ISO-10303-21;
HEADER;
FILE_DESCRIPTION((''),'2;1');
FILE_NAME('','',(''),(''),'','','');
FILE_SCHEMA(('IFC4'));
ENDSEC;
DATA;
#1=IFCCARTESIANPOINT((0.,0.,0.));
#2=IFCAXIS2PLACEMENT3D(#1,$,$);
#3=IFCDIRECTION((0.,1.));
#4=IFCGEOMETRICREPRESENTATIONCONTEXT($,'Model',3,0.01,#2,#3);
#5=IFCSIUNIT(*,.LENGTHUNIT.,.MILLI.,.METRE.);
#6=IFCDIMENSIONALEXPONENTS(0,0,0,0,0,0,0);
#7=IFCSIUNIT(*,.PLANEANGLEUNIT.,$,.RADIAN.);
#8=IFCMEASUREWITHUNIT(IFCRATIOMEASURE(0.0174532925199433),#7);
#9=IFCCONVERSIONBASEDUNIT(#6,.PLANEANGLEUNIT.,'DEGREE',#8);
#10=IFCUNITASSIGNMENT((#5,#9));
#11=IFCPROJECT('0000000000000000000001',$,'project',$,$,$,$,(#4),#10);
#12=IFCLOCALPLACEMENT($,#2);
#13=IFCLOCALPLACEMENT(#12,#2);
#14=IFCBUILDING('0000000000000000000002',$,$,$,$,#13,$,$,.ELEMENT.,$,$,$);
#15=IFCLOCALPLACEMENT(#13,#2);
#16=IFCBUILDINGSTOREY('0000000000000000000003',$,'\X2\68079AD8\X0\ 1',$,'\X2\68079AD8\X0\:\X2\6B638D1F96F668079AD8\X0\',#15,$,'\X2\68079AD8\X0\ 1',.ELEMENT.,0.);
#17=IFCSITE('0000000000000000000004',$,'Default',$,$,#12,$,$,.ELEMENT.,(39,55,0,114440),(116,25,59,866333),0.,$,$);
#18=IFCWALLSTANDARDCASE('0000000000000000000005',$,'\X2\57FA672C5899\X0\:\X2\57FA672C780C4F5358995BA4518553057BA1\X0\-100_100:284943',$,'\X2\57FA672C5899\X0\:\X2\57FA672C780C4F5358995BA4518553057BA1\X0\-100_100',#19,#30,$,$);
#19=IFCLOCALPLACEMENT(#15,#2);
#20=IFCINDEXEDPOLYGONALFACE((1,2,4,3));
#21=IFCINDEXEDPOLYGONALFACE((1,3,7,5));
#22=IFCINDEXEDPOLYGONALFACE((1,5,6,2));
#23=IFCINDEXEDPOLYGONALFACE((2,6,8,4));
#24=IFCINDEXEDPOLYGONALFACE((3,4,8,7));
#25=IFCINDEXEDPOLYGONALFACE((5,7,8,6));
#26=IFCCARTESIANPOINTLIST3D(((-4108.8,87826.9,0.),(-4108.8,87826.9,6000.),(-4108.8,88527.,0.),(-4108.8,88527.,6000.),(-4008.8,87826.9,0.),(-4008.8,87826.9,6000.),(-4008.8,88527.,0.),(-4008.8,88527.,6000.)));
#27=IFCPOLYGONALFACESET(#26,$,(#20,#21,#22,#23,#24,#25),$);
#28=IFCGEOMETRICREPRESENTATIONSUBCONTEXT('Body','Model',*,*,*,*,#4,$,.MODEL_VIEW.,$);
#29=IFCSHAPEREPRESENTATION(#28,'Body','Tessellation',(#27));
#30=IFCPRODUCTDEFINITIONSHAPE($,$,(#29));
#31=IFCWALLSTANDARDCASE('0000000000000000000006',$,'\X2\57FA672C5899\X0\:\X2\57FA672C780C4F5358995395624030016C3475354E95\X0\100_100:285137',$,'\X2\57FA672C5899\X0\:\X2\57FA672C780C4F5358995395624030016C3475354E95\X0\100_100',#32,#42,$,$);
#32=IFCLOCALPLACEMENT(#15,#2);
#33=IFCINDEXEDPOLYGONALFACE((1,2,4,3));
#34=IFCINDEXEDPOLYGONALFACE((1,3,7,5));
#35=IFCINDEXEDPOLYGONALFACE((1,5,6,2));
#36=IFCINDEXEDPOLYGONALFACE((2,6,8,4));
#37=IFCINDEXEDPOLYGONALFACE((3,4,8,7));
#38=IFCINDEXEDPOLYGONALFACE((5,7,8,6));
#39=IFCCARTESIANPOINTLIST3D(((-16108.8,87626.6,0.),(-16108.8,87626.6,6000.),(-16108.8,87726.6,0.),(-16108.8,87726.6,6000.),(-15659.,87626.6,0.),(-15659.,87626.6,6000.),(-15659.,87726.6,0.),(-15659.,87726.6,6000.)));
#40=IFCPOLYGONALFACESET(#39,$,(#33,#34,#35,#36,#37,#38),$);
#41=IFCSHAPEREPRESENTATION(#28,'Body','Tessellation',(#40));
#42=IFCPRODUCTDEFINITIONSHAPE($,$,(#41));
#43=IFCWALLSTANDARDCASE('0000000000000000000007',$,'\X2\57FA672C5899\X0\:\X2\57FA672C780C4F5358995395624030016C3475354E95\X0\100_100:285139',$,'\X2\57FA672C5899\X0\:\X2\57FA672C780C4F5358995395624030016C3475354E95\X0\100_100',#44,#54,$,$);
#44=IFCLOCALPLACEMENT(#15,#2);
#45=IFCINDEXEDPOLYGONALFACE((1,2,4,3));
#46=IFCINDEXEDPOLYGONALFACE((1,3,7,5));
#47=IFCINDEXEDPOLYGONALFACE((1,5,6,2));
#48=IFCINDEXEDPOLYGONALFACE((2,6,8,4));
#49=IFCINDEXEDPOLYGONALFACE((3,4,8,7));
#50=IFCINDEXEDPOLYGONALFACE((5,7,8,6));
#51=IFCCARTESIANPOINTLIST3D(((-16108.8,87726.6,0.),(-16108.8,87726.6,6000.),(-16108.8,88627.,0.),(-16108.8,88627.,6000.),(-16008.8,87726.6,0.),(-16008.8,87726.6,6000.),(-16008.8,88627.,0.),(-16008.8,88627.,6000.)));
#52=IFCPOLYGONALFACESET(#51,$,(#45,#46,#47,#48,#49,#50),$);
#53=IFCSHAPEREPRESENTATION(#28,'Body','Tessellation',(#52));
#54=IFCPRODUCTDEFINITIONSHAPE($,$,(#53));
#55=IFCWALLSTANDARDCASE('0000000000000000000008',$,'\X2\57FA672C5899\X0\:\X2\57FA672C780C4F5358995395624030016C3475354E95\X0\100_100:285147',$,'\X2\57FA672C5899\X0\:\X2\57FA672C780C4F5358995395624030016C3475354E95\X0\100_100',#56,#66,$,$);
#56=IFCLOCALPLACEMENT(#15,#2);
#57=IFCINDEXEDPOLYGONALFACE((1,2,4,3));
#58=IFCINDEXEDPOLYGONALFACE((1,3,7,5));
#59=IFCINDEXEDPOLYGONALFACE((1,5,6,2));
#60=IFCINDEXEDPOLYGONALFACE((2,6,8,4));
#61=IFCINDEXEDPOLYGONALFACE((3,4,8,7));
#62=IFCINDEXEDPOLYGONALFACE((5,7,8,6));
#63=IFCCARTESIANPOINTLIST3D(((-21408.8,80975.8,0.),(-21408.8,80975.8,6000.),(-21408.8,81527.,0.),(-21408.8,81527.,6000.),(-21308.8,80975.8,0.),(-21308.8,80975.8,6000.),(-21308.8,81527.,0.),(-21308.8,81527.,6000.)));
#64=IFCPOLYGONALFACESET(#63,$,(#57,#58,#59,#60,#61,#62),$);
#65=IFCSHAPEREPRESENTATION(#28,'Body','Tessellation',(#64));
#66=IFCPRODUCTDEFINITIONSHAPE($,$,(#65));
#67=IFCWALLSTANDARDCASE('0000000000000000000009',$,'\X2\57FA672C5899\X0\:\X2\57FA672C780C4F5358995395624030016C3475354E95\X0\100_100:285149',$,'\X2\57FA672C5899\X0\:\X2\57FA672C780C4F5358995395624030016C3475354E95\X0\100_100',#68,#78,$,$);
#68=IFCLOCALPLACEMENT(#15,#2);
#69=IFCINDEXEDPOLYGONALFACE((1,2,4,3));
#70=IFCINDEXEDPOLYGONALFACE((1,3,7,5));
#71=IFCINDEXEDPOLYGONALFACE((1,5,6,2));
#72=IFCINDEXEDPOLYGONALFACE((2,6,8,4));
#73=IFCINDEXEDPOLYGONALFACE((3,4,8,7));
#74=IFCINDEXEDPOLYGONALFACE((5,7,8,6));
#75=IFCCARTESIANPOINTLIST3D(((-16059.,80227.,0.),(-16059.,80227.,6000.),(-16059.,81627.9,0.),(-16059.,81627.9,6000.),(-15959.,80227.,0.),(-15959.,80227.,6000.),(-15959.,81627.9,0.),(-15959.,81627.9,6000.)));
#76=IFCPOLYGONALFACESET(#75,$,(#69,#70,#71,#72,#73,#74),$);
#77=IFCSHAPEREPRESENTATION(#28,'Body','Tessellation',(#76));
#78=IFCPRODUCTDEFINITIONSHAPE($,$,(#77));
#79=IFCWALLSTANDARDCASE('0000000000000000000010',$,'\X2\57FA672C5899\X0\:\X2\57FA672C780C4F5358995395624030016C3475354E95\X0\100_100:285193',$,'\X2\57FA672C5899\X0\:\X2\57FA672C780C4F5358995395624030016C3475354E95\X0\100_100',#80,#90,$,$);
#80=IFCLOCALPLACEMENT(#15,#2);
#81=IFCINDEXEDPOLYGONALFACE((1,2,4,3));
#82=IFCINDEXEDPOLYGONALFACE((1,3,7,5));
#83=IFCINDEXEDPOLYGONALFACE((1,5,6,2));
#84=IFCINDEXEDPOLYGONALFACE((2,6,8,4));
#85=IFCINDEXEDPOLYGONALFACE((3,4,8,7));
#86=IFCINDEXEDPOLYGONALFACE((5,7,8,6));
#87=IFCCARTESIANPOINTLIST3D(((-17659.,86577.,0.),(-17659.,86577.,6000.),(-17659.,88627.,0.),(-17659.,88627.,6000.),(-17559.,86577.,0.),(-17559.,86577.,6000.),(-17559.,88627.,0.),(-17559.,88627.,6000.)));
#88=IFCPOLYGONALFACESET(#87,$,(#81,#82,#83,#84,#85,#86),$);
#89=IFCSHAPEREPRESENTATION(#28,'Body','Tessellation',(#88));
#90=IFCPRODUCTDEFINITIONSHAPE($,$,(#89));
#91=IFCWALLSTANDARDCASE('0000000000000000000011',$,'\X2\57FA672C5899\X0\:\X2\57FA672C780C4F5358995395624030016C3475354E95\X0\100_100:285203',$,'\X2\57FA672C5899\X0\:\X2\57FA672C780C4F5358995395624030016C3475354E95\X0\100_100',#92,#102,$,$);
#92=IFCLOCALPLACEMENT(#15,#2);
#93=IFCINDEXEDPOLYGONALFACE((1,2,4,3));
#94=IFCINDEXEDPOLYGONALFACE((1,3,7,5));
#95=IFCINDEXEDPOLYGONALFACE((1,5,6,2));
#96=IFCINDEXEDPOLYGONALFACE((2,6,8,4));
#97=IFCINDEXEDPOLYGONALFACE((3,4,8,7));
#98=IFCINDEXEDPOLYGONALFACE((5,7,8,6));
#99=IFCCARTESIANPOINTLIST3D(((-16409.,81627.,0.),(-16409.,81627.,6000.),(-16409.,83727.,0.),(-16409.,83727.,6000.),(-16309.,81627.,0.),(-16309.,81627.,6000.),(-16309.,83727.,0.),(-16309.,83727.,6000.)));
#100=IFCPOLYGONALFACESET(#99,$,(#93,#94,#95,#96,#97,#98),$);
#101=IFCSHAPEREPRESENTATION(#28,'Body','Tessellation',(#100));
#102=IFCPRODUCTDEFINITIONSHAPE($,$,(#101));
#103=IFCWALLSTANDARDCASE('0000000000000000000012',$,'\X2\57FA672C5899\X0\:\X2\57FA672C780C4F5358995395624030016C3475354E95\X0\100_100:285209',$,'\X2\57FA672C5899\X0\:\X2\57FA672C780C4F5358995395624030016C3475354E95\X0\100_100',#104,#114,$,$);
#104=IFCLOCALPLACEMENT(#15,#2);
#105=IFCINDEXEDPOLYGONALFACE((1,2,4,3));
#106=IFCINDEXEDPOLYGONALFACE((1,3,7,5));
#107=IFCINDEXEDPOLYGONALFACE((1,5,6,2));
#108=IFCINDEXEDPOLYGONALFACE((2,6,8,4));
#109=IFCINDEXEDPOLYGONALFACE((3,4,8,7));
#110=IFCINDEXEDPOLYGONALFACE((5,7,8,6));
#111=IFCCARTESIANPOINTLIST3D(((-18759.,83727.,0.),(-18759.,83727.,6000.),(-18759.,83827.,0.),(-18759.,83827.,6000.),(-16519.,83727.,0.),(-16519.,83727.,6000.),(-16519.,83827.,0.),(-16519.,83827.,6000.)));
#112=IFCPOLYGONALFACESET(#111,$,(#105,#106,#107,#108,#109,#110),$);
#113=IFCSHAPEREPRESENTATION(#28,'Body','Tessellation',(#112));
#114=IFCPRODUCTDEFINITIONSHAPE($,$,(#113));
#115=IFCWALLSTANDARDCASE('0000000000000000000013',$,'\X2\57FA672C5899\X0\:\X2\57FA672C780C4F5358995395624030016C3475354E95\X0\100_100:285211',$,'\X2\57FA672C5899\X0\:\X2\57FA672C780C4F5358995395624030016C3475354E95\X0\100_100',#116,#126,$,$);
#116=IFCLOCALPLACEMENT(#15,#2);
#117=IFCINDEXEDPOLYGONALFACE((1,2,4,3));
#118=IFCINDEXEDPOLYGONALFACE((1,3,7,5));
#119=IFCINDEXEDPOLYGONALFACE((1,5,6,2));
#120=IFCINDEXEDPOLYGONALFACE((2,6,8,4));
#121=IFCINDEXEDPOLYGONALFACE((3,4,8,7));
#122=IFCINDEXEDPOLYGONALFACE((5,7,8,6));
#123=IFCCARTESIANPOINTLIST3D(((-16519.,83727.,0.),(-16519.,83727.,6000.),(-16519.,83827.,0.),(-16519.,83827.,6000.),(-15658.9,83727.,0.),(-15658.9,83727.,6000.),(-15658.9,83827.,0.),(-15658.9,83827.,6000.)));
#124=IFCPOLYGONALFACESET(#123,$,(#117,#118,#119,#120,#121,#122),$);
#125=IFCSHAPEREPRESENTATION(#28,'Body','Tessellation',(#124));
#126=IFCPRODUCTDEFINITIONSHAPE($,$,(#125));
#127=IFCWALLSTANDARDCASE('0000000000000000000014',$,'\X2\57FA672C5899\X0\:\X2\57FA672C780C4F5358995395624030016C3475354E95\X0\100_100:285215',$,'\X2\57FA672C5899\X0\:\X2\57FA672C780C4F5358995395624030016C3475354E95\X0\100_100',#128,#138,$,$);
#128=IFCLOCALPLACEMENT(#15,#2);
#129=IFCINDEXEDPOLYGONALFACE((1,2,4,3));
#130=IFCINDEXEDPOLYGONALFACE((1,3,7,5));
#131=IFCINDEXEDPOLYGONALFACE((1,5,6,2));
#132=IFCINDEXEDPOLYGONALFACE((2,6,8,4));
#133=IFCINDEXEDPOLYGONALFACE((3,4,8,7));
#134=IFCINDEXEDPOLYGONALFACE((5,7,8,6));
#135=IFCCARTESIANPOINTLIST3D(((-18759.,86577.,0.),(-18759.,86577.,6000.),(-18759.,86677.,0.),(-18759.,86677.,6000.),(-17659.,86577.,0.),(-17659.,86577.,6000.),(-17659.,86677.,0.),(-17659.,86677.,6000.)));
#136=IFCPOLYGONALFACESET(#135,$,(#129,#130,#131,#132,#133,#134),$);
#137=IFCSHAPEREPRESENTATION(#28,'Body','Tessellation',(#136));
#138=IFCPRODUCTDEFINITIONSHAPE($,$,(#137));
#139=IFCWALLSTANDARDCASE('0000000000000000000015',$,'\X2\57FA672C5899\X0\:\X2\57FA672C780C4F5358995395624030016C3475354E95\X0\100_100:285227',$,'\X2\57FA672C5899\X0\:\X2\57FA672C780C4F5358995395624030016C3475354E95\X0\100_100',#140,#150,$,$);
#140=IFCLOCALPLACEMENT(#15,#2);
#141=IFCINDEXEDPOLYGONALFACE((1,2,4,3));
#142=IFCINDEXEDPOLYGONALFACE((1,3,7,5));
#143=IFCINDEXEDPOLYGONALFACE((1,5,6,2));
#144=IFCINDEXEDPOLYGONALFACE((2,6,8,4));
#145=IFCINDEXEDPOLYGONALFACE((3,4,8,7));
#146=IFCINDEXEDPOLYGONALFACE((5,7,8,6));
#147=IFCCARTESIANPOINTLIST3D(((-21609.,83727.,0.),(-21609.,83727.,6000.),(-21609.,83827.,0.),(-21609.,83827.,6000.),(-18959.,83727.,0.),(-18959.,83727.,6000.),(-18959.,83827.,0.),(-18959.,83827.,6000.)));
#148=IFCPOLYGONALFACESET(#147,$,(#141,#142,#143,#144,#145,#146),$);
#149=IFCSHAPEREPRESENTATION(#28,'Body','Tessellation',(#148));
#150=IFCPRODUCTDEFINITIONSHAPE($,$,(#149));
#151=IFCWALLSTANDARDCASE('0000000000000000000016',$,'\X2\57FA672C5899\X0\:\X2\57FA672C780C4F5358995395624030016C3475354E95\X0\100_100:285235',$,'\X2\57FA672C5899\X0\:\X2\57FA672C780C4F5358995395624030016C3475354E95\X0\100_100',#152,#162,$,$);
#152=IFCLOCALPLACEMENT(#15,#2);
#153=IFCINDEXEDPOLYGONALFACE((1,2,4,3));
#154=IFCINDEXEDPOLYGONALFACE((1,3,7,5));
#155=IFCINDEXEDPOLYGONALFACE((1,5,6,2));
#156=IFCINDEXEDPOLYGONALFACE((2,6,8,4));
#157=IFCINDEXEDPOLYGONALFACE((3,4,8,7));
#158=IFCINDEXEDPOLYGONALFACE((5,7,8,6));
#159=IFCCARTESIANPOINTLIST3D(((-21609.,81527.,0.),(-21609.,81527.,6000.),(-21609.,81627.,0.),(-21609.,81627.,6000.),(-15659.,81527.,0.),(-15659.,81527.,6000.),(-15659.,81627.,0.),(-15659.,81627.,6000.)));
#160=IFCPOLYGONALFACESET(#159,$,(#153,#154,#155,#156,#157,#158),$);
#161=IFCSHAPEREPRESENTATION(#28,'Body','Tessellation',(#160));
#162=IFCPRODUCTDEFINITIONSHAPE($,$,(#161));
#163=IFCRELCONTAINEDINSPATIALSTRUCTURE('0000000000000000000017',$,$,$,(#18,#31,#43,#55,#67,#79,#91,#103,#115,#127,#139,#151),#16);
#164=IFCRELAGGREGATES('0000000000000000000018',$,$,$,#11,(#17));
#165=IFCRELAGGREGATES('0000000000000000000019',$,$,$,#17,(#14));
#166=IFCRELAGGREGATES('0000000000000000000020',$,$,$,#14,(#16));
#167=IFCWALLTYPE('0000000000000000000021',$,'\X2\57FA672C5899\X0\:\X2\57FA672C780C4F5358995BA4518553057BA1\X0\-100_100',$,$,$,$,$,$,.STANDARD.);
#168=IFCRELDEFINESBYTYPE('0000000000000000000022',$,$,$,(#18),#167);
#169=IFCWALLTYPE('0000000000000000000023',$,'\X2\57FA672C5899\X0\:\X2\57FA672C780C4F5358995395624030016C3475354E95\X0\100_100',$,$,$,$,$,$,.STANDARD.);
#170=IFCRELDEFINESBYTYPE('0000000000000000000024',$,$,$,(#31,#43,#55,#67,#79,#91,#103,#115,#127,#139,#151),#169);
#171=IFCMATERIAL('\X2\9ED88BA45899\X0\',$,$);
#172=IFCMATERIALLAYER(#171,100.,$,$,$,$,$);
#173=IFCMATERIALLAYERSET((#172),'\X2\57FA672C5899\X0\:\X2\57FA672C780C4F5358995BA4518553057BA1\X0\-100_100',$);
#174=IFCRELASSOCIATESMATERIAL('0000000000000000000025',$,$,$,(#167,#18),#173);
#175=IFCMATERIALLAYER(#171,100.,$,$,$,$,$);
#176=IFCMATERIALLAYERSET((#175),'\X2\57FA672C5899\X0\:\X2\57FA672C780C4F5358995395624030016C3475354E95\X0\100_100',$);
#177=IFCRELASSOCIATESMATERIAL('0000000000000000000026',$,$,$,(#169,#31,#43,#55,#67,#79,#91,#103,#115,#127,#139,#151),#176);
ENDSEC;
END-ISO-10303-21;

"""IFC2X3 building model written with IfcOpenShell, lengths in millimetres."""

from ifc_helpers import new_model, entity, si_unit, converted_unit, direction, frame, frame_2d, origin, place, context, subcontext, project, spatial, rectangle, extrude, material, layer, layer_set, layer_usage, type_object, element, save


model = new_model("IFC2X3")

# Units and contexts
model_context = context("Model", 3, precision=0.01, world=origin(), true_north=direction((0.0, 1.0)))
body_context = subcontext(model_context, "Body", "Model", "MODEL_VIEW")
ifc_project = project(units=[si_unit("LENGTHUNIT", "METRE", prefix="MILLI"), converted_unit("PLANEANGLEUNIT", "DEGREE", entity("IfcRatioMeasure", 0.0174532925199433), si_unit("PLANEANGLEUNIT", "RADIAN"), dimensions=[0, 0, 0, 0, 0, 0, 0])], contexts=[model_context])

# Site, building, storey
site_placement = place(None, origin())
site = spatial("IfcSite", under=ifc_project, at=site_placement, Name="Default", CompositionType="ELEMENT", RefLatitude=(39, 55, 0, 114440), RefLongitude=(116, 25, 59, 866333), RefElevation=0.0)
building_placement = place(site_placement, origin())
building = spatial("IfcBuilding", under=site, at=building_placement, CompositionType="ELEMENT")
storey_placement = place(building_placement, origin())
storey = spatial("IfcBuildingStorey", under=building, at=storey_placement, Name="标高 1", ObjectType="标高:正负零标高", LongName="标高 1", CompositionType="ELEMENT", Elevation=0.0)

# Walls
ifc_material = material(Name="默认墙")
ifc_layer_1 = layer(ifc_material, 100.0)
ifc_layer_set_1 = layer_set([ifc_layer_1], Name="基本墙:基本砌体墙室内包管-100_100")
wall_type_1 = type_object("IfcWallType", Name="基本墙:基本砌体墙室内包管-100_100", PredefinedType="STANDARD", material=ifc_layer_set_1)
ifc_layer_usage_1 = layer_usage(ifc_layer_set_1, "AXIS2", "NEGATIVE", 50.0)
wall_1_placement = place(building_placement, frame((-4058.8, 87826.9, 0.0), z_axis=(0.0, 0.0, 1.0), x_axis=(0.0, 1.0, 0.0)))
element("IfcWallStandardCase", 1, at=wall_1_placement, inside=storey, type_object=wall_type_1, material=ifc_layer_usage_1, Name="基本墙:基本砌体墙室内包管-100_100:284943", ObjectType="基本墙:基本砌体墙室内包管-100_100", context=body_context, shape_type="SweptSolid", body=[
    extrude(rectangle(XDim=700.1, YDim=100.0, at=frame_2d((350.0, 0.0), x_axis=(-1.0, 0.0))), origin(), (0.0, 0.0, 1.0), 6000.0),
])
ifc_layer_2 = layer(ifc_material, 100.0)
ifc_layer_set_2 = layer_set([ifc_layer_2], Name="基本墙:基本砌体墙厕所、水电井100_100")
ifc_layer_usage_2 = layer_usage(ifc_layer_set_2, "AXIS2", "NEGATIVE", 50.0)
wall_type_2 = type_object("IfcWallType", Name="基本墙:基本砌体墙厕所、水电井100_100", PredefinedType="STANDARD", material=ifc_layer_set_2)
wall_2_placement = place(building_placement, frame((-16108.8, 87676.6, 0.0)))
element("IfcWallStandardCase", 2, at=wall_2_placement, inside=storey, type_object=wall_type_2, material=ifc_layer_usage_2, Name="基本墙:基本砌体墙厕所、水电井100_100:285137", ObjectType="基本墙:基本砌体墙厕所、水电井100_100", context=body_context, shape_type="SweptSolid", body=[
    extrude(rectangle(XDim=449.8, YDim=100.0, at=frame_2d((224.9, 0.0), x_axis=(-1.0, 0.0))), origin(), (0.0, 0.0, 1.0), 6000.0),
])
ifc_layer_usage_3 = layer_usage(ifc_layer_set_2, "AXIS2", "NEGATIVE", 50.0)
wall_3_placement = place(building_placement, frame((-16058.8, 87726.6, 0.0), z_axis=(0.0, 0.0, 1.0), x_axis=(0.0, 1.0, 0.0)))
element("IfcWallStandardCase", 3, at=wall_3_placement, inside=storey, type_object=wall_type_2, material=ifc_layer_usage_3, Name="基本墙:基本砌体墙厕所、水电井100_100:285139", ObjectType="基本墙:基本砌体墙厕所、水电井100_100", context=body_context, shape_type="SweptSolid", body=[
    extrude(rectangle(XDim=900.5, YDim=100.0, at=frame_2d((450.2, 0.0), x_axis=(-1.0, 0.0))), origin(), (0.0, 0.0, 1.0), 6000.0),
])
ifc_layer_usage_4 = layer_usage(ifc_layer_set_2, "AXIS2", "NEGATIVE", 50.0)
wall_4_placement = place(building_placement, frame((-21358.8, 80975.8, 0.0), z_axis=(0.0, 0.0, 1.0), x_axis=(0.0, 1.0, 0.0)))
element("IfcWallStandardCase", 4, at=wall_4_placement, inside=storey, type_object=wall_type_2, material=ifc_layer_usage_4, Name="基本墙:基本砌体墙厕所、水电井100_100:285147", ObjectType="基本墙:基本砌体墙厕所、水电井100_100", context=body_context, shape_type="SweptSolid", body=[
    extrude(rectangle(XDim=551.2, YDim=100.0, at=frame_2d((275.6, 0.0), x_axis=(-1.0, 0.0))), origin(), (0.0, 0.0, 1.0), 6000.0),
])
ifc_layer_usage_5 = layer_usage(ifc_layer_set_2, "AXIS2", "NEGATIVE", 50.0)
wall_5_placement = place(building_placement, frame((-16009.0, 81627.9, 0.0), z_axis=(0.0, 0.0, 1.0), x_axis=(0.0, -1.0, 0.0)))
element("IfcWallStandardCase", 5, at=wall_5_placement, inside=storey, type_object=wall_type_2, material=ifc_layer_usage_5, Name="基本墙:基本砌体墙厕所、水电井100_100:285149", ObjectType="基本墙:基本砌体墙厕所、水电井100_100", context=body_context, shape_type="SweptSolid", body=[
    extrude(rectangle(XDim=1400.9, YDim=100.0, at=frame_2d((700.5, 0.0), x_axis=(-1.0, 0.0))), origin(), (0.0, 0.0, 1.0), 6000.0),
])
ifc_layer_usage_6 = layer_usage(ifc_layer_set_2, "AXIS2", "NEGATIVE", 50.0)
wall_6_placement = place(building_placement, frame((-17609.0, 88627.0, 0.0), z_axis=(0.0, 0.0, 1.0), x_axis=(0.0, -1.0, 0.0)))
element("IfcWallStandardCase", 6, at=wall_6_placement, inside=storey, type_object=wall_type_2, material=ifc_layer_usage_6, Name="基本墙:基本砌体墙厕所、水电井100_100:285193", ObjectType="基本墙:基本砌体墙厕所、水电井100_100", context=body_context, shape_type="SweptSolid", body=[
    extrude(rectangle(XDim=2050.0, YDim=100.0, at=frame_2d((1025.0, 0.0), x_axis=(-1.0, 0.0))), origin(), (0.0, 0.0, 1.0), 6000.0),
])
ifc_layer_usage_7 = layer_usage(ifc_layer_set_2, "AXIS2", "NEGATIVE", 50.0)
wall_7_placement = place(building_placement, frame((-16359.0, 83727.0, 0.0), z_axis=(0.0, 0.0, 1.0), x_axis=(0.0, -1.0, 0.0)))
element("IfcWallStandardCase", 7, at=wall_7_placement, inside=storey, type_object=wall_type_2, material=ifc_layer_usage_7, Name="基本墙:基本砌体墙厕所、水电井100_100:285203", ObjectType="基本墙:基本砌体墙厕所、水电井100_100", context=body_context, shape_type="SweptSolid", body=[
    extrude(rectangle(XDim=2100.0, YDim=100.0, at=frame_2d((1050.0, 0.0), x_axis=(-1.0, 0.0))), origin(), (0.0, 0.0, 1.0), 6000.0),
])
ifc_layer_usage_8 = layer_usage(ifc_layer_set_2, "AXIS2", "NEGATIVE", 50.0)
wall_8_placement = place(building_placement, frame((-18759.0, 83777.0, 0.0)))
element("IfcWallStandardCase", 8, at=wall_8_placement, inside=storey, type_object=wall_type_2, material=ifc_layer_usage_8, Name="基本墙:基本砌体墙厕所、水电井100_100:285209", ObjectType="基本墙:基本砌体墙厕所、水电井100_100", context=body_context, shape_type="SweptSolid", body=[
    extrude(rectangle(XDim=2240.0, YDim=100.0, at=frame_2d((1120.0, 0.0), x_axis=(-1.0, 0.0))), origin(), (0.0, 0.0, 1.0), 6000.0),
])
ifc_layer_usage_9 = layer_usage(ifc_layer_set_2, "AXIS2", "NEGATIVE", 50.0)
wall_9_placement = place(building_placement, frame((-16519.0, 83777.0, 0.0)))
element("IfcWallStandardCase", 9, at=wall_9_placement, inside=storey, type_object=wall_type_2, material=ifc_layer_usage_9, Name="基本墙:基本砌体墙厕所、水电井100_100:285211", ObjectType="基本墙:基本砌体墙厕所、水电井100_100", context=body_context, shape_type="SweptSolid", body=[
    extrude(rectangle(XDim=860.1, YDim=100.0, at=frame_2d((430.1, 0.0), x_axis=(-1.0, 0.0))), origin(), (0.0, 0.0, 1.0), 6000.0),
])
ifc_layer_usage_10 = layer_usage(ifc_layer_set_2, "AXIS2", "NEGATIVE", 50.0)
wall_10_placement = place(building_placement, frame((-17659.0, 86627.0, 0.0), z_axis=(0.0, 0.0, 1.0), x_axis=(-1.0, 0.0, 0.0)))
element("IfcWallStandardCase", 10, at=wall_10_placement, inside=storey, type_object=wall_type_2, material=ifc_layer_usage_10, Name="基本墙:基本砌体墙厕所、水电井100_100:285215", ObjectType="基本墙:基本砌体墙厕所、水电井100_100", context=body_context, shape_type="SweptSolid", body=[
    extrude(rectangle(XDim=1100.0, YDim=100.0, at=frame_2d((550.0, 0.0), x_axis=(-1.0, 0.0))), origin(), (0.0, 0.0, 1.0), 6000.0),
])
ifc_layer_usage_11 = layer_usage(ifc_layer_set_2, "AXIS2", "NEGATIVE", 50.0)
wall_11_placement = place(building_placement, frame((-21609.0, 83777.0, 0.0)))
element("IfcWallStandardCase", 11, at=wall_11_placement, inside=storey, type_object=wall_type_2, material=ifc_layer_usage_11, Name="基本墙:基本砌体墙厕所、水电井100_100:285227", ObjectType="基本墙:基本砌体墙厕所、水电井100_100", context=body_context, shape_type="SweptSolid", body=[
    extrude(rectangle(XDim=2650.0, YDim=100.0, at=frame_2d((1325.0, 0.0), x_axis=(-1.0, 0.0))), origin(), (0.0, 0.0, 1.0), 6000.0),
])
ifc_layer_usage_12 = layer_usage(ifc_layer_set_2, "AXIS2", "NEGATIVE", 50.0)
wall_12_placement = place(building_placement, frame((-21609.0, 81577.0, 0.0)))
element("IfcWallStandardCase", 12, at=wall_12_placement, inside=storey, type_object=wall_type_2, material=ifc_layer_usage_12, Name="基本墙:基本砌体墙厕所、水电井100_100:285235", ObjectType="基本墙:基本砌体墙厕所、水电井100_100", context=body_context, shape_type="SweptSolid", body=[
    extrude(rectangle(XDim=5950.0, YDim=100.0, at=frame_2d((2975.0, 0.0), x_axis=(-1.0, 0.0))), origin(), (0.0, 0.0, 1.0), 6000.0),
])

save(model, "model.ifc")
